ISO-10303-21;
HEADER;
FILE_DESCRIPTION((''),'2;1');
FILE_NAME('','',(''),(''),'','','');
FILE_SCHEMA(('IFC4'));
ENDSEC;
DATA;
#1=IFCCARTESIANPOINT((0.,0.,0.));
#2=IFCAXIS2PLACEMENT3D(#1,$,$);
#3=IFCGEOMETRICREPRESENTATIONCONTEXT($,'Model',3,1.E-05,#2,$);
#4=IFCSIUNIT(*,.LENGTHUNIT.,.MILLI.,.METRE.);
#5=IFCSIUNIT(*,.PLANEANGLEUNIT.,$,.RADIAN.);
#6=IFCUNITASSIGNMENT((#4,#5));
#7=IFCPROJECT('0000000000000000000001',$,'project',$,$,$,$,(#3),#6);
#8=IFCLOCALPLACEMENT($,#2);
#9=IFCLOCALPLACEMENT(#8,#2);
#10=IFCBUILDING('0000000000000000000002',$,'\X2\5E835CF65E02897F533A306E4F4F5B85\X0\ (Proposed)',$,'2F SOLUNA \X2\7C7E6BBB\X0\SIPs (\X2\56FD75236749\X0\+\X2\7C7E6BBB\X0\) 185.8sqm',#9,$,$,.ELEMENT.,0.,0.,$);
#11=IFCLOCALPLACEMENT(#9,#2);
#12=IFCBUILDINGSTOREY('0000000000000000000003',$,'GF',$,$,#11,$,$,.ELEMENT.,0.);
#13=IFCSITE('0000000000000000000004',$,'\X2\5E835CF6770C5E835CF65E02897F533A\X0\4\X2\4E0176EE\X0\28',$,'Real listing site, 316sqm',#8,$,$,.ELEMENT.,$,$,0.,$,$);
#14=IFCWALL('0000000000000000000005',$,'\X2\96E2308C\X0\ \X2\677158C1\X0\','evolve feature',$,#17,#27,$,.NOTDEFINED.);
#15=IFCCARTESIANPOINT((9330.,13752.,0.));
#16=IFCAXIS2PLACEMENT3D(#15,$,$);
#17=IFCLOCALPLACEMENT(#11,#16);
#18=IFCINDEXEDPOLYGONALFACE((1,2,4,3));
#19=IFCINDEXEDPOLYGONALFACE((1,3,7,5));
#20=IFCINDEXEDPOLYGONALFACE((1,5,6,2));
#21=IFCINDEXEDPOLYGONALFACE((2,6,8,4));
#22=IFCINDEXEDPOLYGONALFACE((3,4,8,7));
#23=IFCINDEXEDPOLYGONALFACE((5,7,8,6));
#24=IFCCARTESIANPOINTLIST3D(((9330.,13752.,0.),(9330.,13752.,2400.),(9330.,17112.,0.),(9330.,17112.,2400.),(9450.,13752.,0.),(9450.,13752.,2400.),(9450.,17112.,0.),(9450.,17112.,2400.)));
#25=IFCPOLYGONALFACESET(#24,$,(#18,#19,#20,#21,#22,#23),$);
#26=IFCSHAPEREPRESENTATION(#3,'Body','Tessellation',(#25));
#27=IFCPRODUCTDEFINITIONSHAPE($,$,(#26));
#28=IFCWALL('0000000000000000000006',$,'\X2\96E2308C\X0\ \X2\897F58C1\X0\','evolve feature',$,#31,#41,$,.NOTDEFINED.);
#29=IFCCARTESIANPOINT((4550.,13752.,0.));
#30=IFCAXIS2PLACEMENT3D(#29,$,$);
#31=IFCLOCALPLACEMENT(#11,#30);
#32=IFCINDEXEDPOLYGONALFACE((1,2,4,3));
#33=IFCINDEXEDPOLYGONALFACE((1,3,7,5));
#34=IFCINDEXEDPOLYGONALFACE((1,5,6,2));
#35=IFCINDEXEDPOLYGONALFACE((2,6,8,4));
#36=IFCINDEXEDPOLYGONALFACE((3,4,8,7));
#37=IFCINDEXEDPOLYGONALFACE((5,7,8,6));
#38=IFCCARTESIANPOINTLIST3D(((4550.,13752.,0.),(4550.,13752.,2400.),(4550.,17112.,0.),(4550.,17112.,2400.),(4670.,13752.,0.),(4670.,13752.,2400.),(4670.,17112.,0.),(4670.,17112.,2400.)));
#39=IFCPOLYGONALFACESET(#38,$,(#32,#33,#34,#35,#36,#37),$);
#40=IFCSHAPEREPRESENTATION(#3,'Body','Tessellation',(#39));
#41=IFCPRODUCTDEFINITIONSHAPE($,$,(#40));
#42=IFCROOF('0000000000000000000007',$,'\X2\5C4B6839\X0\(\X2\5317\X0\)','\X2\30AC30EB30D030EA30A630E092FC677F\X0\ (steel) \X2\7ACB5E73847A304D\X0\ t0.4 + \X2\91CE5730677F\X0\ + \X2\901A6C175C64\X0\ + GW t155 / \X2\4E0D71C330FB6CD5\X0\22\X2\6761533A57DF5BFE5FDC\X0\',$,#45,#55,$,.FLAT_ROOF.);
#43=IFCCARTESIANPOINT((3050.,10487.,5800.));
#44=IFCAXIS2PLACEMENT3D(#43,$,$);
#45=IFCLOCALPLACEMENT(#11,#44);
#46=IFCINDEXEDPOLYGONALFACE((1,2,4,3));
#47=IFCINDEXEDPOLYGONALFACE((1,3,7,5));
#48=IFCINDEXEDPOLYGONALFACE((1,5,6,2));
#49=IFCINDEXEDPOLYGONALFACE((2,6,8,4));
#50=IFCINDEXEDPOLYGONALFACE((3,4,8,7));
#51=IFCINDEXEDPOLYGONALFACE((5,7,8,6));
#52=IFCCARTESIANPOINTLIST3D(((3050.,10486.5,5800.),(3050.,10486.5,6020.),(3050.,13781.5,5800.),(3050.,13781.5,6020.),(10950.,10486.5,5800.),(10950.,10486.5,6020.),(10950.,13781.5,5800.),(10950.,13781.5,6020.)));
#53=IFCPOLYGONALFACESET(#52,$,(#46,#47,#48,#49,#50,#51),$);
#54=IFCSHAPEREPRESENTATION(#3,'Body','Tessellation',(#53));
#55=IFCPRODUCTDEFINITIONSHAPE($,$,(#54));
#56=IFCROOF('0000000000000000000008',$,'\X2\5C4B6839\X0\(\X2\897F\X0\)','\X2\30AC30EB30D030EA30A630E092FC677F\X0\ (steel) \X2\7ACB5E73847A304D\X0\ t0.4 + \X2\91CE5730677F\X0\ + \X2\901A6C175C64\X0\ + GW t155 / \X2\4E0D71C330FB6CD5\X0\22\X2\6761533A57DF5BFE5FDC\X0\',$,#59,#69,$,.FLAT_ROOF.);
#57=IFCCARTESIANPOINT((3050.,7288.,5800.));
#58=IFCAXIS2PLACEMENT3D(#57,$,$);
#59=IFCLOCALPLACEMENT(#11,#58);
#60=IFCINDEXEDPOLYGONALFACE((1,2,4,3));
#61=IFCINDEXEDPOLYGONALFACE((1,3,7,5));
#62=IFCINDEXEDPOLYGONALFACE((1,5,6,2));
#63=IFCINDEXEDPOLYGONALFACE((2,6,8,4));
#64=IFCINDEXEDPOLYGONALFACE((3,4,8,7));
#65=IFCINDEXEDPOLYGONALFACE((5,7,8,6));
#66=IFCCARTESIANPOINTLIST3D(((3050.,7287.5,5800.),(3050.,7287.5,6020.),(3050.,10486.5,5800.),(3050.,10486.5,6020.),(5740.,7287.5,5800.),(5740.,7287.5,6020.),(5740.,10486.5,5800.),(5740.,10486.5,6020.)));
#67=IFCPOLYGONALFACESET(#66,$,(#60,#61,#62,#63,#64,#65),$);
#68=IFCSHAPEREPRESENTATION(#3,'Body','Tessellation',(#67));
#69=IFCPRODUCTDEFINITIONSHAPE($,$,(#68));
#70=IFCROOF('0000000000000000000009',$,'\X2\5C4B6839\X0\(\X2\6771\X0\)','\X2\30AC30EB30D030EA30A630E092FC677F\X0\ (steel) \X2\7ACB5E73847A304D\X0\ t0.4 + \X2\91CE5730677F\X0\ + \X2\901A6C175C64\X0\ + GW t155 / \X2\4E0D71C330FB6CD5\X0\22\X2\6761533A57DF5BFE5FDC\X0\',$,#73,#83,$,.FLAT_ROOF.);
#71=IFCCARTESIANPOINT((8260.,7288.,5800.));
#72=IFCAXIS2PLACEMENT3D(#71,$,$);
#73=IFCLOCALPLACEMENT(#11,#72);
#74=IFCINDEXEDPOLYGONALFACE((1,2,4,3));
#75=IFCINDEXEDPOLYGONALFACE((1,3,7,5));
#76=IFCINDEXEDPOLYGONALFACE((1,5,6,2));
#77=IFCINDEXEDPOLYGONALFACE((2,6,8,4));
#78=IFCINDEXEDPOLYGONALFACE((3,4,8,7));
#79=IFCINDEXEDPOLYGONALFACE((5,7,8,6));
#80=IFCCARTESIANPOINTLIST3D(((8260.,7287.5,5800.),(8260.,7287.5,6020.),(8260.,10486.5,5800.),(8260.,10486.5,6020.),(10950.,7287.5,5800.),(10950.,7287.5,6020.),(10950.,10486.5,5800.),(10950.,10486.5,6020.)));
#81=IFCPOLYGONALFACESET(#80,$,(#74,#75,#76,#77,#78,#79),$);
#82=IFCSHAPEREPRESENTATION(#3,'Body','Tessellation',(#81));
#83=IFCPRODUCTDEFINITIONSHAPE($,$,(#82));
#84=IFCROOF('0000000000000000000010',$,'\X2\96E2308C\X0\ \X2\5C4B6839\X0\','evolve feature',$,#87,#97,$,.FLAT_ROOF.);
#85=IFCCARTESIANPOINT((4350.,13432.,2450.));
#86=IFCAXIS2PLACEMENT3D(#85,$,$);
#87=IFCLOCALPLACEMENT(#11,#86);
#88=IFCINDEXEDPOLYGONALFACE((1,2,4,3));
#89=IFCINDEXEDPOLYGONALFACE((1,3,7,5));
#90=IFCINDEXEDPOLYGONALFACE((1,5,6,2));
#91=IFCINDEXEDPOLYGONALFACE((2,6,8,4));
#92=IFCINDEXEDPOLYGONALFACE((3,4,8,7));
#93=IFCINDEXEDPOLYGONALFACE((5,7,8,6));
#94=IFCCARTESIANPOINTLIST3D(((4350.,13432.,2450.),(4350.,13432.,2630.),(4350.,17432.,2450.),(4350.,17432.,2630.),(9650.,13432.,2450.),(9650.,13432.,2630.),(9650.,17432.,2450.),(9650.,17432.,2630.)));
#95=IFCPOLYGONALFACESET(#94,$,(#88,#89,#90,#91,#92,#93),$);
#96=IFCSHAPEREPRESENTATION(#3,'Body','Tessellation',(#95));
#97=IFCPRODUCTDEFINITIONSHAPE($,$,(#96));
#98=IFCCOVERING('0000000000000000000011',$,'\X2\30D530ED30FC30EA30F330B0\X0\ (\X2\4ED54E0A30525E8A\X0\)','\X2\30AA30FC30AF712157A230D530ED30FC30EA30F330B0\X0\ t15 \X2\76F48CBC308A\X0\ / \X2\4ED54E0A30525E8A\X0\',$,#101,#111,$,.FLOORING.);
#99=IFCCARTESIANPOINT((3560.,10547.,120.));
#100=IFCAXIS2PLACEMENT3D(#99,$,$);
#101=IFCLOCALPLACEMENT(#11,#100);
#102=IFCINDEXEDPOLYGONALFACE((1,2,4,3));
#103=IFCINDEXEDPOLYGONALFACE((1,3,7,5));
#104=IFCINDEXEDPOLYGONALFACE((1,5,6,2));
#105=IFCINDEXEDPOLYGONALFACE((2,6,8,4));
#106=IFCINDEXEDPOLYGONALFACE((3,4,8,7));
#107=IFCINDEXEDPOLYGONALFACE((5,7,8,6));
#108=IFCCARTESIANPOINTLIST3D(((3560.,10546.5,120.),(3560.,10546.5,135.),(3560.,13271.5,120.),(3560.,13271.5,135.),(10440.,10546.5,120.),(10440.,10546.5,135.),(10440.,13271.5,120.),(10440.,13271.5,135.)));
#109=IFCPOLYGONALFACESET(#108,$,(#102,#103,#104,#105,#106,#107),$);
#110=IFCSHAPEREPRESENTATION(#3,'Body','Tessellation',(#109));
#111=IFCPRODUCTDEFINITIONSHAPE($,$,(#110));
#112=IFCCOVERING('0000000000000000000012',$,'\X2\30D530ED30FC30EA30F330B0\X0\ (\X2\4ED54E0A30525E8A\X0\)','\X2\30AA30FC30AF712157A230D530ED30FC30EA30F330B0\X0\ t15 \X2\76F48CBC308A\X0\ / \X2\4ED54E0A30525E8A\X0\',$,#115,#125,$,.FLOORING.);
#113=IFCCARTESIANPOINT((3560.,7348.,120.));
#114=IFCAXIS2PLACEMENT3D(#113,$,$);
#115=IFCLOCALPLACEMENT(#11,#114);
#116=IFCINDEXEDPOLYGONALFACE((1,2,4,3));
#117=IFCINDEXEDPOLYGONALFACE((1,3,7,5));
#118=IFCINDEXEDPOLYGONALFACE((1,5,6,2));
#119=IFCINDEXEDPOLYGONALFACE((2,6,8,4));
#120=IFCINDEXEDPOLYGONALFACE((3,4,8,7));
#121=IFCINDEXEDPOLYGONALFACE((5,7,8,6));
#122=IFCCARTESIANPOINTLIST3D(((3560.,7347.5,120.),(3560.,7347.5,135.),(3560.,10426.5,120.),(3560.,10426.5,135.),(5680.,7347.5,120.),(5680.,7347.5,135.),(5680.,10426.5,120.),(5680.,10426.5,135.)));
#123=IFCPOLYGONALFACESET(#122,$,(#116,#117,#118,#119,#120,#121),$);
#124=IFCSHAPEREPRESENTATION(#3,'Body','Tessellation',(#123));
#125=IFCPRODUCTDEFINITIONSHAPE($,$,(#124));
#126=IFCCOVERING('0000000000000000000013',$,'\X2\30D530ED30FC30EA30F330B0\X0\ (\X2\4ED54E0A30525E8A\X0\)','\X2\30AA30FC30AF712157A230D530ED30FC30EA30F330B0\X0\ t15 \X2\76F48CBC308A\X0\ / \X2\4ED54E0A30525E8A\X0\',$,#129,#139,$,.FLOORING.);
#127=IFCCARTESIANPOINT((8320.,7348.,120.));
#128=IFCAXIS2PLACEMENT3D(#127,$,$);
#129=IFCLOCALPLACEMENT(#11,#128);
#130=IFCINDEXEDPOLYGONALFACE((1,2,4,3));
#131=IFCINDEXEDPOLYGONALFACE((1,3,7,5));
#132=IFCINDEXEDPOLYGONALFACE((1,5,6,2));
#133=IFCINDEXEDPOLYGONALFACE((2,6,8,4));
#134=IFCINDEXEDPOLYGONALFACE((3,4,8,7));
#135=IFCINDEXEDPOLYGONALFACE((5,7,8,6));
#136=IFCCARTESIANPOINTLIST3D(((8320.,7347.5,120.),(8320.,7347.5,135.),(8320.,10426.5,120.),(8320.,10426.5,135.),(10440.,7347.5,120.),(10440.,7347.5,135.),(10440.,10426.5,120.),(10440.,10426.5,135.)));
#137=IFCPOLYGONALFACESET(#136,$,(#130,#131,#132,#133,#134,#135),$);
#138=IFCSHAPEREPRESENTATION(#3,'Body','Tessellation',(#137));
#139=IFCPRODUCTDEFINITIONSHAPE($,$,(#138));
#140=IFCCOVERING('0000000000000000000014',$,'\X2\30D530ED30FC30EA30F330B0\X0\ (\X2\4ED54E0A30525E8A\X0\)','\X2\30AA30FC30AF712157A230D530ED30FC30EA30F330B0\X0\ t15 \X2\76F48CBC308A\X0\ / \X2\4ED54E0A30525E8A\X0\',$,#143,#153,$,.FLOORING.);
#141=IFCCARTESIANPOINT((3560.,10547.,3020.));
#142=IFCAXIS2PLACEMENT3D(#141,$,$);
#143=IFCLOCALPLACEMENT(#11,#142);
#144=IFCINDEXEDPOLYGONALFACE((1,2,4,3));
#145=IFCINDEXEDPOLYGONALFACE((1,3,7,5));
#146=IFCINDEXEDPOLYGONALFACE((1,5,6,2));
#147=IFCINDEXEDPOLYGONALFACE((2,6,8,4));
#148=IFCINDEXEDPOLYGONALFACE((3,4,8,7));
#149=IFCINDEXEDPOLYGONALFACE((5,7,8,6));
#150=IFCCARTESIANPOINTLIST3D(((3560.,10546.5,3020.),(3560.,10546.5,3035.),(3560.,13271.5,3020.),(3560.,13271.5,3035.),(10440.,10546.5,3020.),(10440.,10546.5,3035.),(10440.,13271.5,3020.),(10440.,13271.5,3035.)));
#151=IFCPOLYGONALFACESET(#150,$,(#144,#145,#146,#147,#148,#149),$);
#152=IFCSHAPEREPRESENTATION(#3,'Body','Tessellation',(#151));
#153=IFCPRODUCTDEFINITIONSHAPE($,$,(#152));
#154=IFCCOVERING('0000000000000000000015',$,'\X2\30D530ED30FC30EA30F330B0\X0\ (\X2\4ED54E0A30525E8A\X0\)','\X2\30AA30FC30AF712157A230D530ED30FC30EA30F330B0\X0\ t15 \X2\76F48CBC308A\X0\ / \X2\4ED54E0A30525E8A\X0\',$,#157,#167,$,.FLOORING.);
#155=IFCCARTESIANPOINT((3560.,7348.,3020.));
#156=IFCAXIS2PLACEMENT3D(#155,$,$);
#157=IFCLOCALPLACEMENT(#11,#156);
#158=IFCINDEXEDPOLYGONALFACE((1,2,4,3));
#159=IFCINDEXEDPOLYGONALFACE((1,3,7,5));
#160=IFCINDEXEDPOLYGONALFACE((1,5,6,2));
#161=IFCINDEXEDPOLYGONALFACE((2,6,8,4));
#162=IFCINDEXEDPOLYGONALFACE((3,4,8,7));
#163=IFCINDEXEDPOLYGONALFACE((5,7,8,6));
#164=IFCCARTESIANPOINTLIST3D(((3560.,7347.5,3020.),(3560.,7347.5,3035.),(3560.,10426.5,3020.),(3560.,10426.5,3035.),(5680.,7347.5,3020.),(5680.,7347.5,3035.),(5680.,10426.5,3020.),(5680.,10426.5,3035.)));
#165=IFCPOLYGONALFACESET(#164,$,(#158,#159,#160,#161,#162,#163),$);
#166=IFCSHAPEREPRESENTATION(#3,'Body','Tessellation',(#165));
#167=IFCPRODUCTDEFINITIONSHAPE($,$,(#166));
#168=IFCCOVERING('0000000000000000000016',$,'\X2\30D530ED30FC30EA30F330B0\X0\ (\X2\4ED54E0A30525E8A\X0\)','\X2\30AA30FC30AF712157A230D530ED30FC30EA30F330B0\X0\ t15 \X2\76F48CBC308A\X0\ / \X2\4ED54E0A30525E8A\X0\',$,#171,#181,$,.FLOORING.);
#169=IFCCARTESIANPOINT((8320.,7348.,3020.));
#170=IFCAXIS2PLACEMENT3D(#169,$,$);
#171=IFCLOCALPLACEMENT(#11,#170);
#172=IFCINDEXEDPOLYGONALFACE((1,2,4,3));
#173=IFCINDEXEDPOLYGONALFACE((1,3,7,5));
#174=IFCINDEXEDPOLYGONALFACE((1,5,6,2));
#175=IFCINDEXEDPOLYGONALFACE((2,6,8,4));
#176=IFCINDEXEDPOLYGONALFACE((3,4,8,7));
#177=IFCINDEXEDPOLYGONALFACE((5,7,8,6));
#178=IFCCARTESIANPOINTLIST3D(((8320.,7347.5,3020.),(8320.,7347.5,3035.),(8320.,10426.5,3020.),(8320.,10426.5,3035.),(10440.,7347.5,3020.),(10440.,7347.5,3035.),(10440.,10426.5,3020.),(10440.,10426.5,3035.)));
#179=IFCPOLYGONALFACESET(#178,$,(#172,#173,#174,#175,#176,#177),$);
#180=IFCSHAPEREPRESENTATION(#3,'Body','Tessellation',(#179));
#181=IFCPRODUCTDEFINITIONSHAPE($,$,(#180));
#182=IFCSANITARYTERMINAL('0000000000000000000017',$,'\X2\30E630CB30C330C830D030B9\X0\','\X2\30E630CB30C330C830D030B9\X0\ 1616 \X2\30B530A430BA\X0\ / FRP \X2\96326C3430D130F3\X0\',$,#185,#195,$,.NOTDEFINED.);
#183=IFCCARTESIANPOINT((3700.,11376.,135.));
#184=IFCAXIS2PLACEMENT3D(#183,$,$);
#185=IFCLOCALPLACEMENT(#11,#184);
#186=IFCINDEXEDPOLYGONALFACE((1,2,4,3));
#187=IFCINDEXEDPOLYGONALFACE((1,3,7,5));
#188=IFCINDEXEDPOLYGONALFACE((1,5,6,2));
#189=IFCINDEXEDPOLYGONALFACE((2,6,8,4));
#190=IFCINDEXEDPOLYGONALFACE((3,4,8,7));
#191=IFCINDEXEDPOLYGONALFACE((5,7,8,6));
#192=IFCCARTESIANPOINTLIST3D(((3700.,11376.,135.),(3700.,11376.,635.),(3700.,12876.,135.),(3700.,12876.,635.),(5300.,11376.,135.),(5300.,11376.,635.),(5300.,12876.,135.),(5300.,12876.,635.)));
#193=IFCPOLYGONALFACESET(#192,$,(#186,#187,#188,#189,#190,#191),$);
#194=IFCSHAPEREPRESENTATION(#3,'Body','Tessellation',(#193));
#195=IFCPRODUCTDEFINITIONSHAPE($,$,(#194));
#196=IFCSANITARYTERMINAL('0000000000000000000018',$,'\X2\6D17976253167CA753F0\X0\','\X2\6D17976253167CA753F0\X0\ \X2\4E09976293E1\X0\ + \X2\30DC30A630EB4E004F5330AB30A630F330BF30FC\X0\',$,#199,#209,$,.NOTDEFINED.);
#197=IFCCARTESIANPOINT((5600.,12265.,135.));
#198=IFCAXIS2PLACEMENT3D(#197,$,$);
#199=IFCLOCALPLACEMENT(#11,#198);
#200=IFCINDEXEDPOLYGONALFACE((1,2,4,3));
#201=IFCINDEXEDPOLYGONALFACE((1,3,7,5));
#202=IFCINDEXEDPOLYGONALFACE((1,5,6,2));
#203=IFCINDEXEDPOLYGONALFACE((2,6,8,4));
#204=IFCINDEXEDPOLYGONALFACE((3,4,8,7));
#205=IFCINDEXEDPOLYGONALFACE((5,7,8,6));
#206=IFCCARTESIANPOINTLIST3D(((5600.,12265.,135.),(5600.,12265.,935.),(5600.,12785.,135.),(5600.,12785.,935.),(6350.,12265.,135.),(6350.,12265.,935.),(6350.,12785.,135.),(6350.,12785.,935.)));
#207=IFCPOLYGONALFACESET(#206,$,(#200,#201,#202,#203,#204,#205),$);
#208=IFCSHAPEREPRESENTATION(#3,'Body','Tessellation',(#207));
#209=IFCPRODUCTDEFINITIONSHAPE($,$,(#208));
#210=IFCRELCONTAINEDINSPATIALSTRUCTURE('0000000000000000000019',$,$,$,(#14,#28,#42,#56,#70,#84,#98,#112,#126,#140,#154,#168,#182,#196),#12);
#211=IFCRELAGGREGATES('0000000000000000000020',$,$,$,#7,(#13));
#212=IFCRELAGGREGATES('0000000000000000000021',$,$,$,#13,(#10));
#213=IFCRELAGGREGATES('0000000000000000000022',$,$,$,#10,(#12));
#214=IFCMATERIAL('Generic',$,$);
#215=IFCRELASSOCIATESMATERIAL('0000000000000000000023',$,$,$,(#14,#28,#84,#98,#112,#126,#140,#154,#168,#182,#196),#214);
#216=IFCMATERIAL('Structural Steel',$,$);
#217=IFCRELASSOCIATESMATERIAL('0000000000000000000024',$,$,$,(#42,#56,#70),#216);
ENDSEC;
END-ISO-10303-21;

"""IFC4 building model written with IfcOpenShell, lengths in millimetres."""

from ifc_helpers import new_model, si_unit, frame, frame_2d, origin, place, context, project, spatial, rectangle, extrude, material, element, save


model = new_model("IFC4")

# Units and contexts
model_context = context("Model", 3, precision=1e-05, world=origin())
ifc_project = project(units=[si_unit("LENGTHUNIT", "METRE", prefix="MILLI"), si_unit("PLANEANGLEUNIT", "RADIAN")], contexts=[model_context])

# Site, building, storey
site_placement = place(None, origin())
site = spatial("IfcSite", under=ifc_project, at=site_placement, Name="広島県広島市西区4丁目28", ObjectType="Real listing site, 316sqm", CompositionType="ELEMENT", RefElevation=0.0)
building_placement = place(site_placement, origin())
building = spatial("IfcBuilding", under=site, at=building_placement, Name="広島市西区の住宅 (Proposed)", ObjectType="2F SOLUNA 籾殻SIPs (国産杉+籾殻) 185.8sqm", CompositionType="ELEMENT", ElevationOfRefHeight=0.0, ElevationOfTerrain=0.0)
storey_placement = place(building_placement, origin())
storey = spatial("IfcBuildingStorey", under=building, at=storey_placement, Name="GF", CompositionType="ELEMENT", Elevation=0.0)

# Shared definitions
ifc_material_1 = material(Name="Generic")

# Walls
wall_1_placement = place(storey_placement, frame((9330.0, 13752.0, 0.0)))
element("IfcWall", 1, at=wall_1_placement, inside=storey, material=ifc_material_1, Name="離れ 東壁", Description="evolve feature", PredefinedType="NOTDEFINED", context=model_context, shape_type="SweptSolid", body=[
    extrude(rectangle(XDim=120.0, YDim=3360.0, at=frame_2d((60.0, 1680.0))), frame((9330.0, 13752.0, 0.0)), (0.0, 0.0, 1.0), 2400.0),
])
wall_2_placement = place(storey_placement, frame((4550.0, 13752.0, 0.0)))
element("IfcWall", 2, at=wall_2_placement, inside=storey, material=ifc_material_1, Name="離れ 西壁", Description="evolve feature", PredefinedType="NOTDEFINED", context=model_context, shape_type="SweptSolid", body=[
    extrude(rectangle(XDim=120.0, YDim=3360.0, at=frame_2d((60.0, 1680.0))), frame((4550.0, 13752.0, 0.0)), (0.0, 0.0, 1.0), 2400.0),
])

# Roofs
ifc_material_2 = material(Name="Structural Steel")
for number, where, name in (
    (3, (3050.0, 10487.0, 5800.0), "屋根(北)"),
):
    element("IfcRoof", number, at=place(storey_placement, frame(where)), inside=storey, material=ifc_material_2, Name=name, Description="ガルバリウム鋼板 (steel) 立平葺き t0.4 + 野地板 + 通気層 + GW t155 / 不燃・法22条区域対応", PredefinedType="FLAT_ROOF", context=model_context, shape_type="SweptSolid", body=[
        extrude(rectangle(XDim=7900.0, YDim=3295.0, at=frame_2d((3950.0, 1647.0))), frame((3050.0, 10487.0, 5800.0)), (0.0, 0.0, 1.0), 220.0),
    ])
roof_1_placement = place(storey_placement, frame((3050.0, 7288.0, 5800.0)))
element("IfcRoof", 4, at=roof_1_placement, inside=storey, material=ifc_material_2, Name="屋根(西)", Description="ガルバリウム鋼板 (steel) 立平葺き t0.4 + 野地板 + 通気層 + GW t155 / 不燃・法22条区域対応", PredefinedType="FLAT_ROOF", context=model_context, shape_type="SweptSolid", body=[
    extrude(rectangle(XDim=2690.0, YDim=3199.0, at=frame_2d((1345.0, 1599.0))), frame((3050.0, 7288.0, 5800.0)), (0.0, 0.0, 1.0), 220.0),
])
roof_2_placement = place(storey_placement, frame((8260.0, 7288.0, 5800.0)))
element("IfcRoof", 5, at=roof_2_placement, inside=storey, material=ifc_material_2, Name="屋根(東)", Description="ガルバリウム鋼板 (steel) 立平葺き t0.4 + 野地板 + 通気層 + GW t155 / 不燃・法22条区域対応", PredefinedType="FLAT_ROOF", context=model_context, shape_type="SweptSolid", body=[
    extrude(rectangle(XDim=2690.0, YDim=3199.0, at=frame_2d((1345.0, 1599.0))), frame((8260.0, 7288.0, 5800.0)), (0.0, 0.0, 1.0), 220.0),
])
roof_3_placement = place(storey_placement, frame((4350.0, 13432.0, 2450.0)))
element("IfcRoof", 6, at=roof_3_placement, inside=storey, material=ifc_material_1, Name="離れ 屋根", Description="evolve feature", PredefinedType="FLAT_ROOF", context=model_context, shape_type="SweptSolid", body=[
    extrude(rectangle(XDim=5300.0, YDim=4000.0, at=frame_2d((2650.0, 2000.0))), frame((4350.0, 13432.0, 2450.0)), (0.0, 0.0, 1.0), 180.0),
])

# Coverings
covering_1_placement = place(storey_placement, frame((3560.0, 10547.0, 120.0)))
element("IfcCovering", 7, at=covering_1_placement, inside=storey, material=ifc_material_1, Name="フローリング (仕上げ床)", Description="オーク無垢フローリング t15 直貼り / 仕上げ床", PredefinedType="FLOORING", context=model_context, shape_type="SweptSolid", body=[
    extrude(rectangle(XDim=6880.0, YDim=2725.0, at=frame_2d((3440.0, 1362.0))), frame((3560.0, 10547.0, 120.0)), (0.0, 0.0, 1.0), 15.0),
])
covering_2_placement = place(storey_placement, frame((3560.0, 7348.0, 120.0)))
element("IfcCovering", 8, at=covering_2_placement, inside=storey, material=ifc_material_1, Name="フローリング (仕上げ床)", Description="オーク無垢フローリング t15 直貼り / 仕上げ床", PredefinedType="FLOORING", context=model_context, shape_type="SweptSolid", body=[
    extrude(rectangle(XDim=2120.0, YDim=3079.0, at=frame_2d((1060.0, 1539.0))), frame((3560.0, 7348.0, 120.0)), (0.0, 0.0, 1.0), 15.0),
])
covering_3_placement = place(storey_placement, frame((8320.0, 7348.0, 120.0)))
element("IfcCovering", 9, at=covering_3_placement, inside=storey, material=ifc_material_1, Name="フローリング (仕上げ床)", Description="オーク無垢フローリング t15 直貼り / 仕上げ床", PredefinedType="FLOORING", context=model_context, shape_type="SweptSolid", body=[
    extrude(rectangle(XDim=2120.0, YDim=3079.0, at=frame_2d((1060.0, 1539.0))), frame((8320.0, 7348.0, 120.0)), (0.0, 0.0, 1.0), 15.0),
])
covering_4_placement = place(storey_placement, frame((3560.0, 10547.0, 3020.0)))
element("IfcCovering", 10, at=covering_4_placement, inside=storey, material=ifc_material_1, Name="フローリング (仕上げ床)", Description="オーク無垢フローリング t15 直貼り / 仕上げ床", PredefinedType="FLOORING", context=model_context, shape_type="SweptSolid", body=[
    extrude(rectangle(XDim=6880.0, YDim=2725.0, at=frame_2d((3440.0, 1362.0))), frame((3560.0, 10547.0, 3020.0)), (0.0, 0.0, 1.0), 15.0),
])
covering_5_placement = place(storey_placement, frame((3560.0, 7348.0, 3020.0)))
element("IfcCovering", 11, at=covering_5_placement, inside=storey, material=ifc_material_1, Name="フローリング (仕上げ床)", Description="オーク無垢フローリング t15 直貼り / 仕上げ床", PredefinedType="FLOORING", context=model_context, shape_type="SweptSolid", body=[
    extrude(rectangle(XDim=2120.0, YDim=3079.0, at=frame_2d((1060.0, 1539.0))), frame((3560.0, 7348.0, 3020.0)), (0.0, 0.0, 1.0), 15.0),
])
covering_6_placement = place(storey_placement, frame((8320.0, 7348.0, 3020.0)))
element("IfcCovering", 12, at=covering_6_placement, inside=storey, material=ifc_material_1, Name="フローリング (仕上げ床)", Description="オーク無垢フローリング t15 直貼り / 仕上げ床", PredefinedType="FLOORING", context=model_context, shape_type="SweptSolid", body=[
    extrude(rectangle(XDim=2120.0, YDim=3079.0, at=frame_2d((1060.0, 1539.0))), frame((8320.0, 7348.0, 3020.0)), (0.0, 0.0, 1.0), 15.0),
])

# Sanitary terminals
sanitary_terminal_1_placement = place(storey_placement, frame((3700.0, 11376.0, 135.0)))
element("IfcSanitaryTerminal", 13, at=sanitary_terminal_1_placement, inside=storey, material=ifc_material_1, Name="ユニットバス", Description="ユニットバス 1616 サイズ / FRP 防水パン", PredefinedType="NOTDEFINED", context=model_context, shape_type="SweptSolid", body=[
    extrude(rectangle(XDim=1600.0, YDim=1500.0, at=frame_2d((800.0, 750.0))), frame((3700.0, 11376.0, 135.0)), (0.0, 0.0, 1.0), 500.0),
])
sanitary_terminal_2_placement = place(storey_placement, frame((5600.0, 12265.0, 135.0)))
element("IfcSanitaryTerminal", 14, at=sanitary_terminal_2_placement, inside=storey, material=ifc_material_1, Name="洗面化粧台", Description="洗面化粧台 三面鏡 + ボウル一体カウンター", PredefinedType="NOTDEFINED", context=model_context, shape_type="SweptSolid", body=[
    extrude(rectangle(XDim=750.0, YDim=520.0, at=frame_2d((375.0, 260.0))), frame((5600.0, 12265.0, 135.0)), (0.0, 0.0, 1.0), 800.0),
])

save(model, "model.ifc")
